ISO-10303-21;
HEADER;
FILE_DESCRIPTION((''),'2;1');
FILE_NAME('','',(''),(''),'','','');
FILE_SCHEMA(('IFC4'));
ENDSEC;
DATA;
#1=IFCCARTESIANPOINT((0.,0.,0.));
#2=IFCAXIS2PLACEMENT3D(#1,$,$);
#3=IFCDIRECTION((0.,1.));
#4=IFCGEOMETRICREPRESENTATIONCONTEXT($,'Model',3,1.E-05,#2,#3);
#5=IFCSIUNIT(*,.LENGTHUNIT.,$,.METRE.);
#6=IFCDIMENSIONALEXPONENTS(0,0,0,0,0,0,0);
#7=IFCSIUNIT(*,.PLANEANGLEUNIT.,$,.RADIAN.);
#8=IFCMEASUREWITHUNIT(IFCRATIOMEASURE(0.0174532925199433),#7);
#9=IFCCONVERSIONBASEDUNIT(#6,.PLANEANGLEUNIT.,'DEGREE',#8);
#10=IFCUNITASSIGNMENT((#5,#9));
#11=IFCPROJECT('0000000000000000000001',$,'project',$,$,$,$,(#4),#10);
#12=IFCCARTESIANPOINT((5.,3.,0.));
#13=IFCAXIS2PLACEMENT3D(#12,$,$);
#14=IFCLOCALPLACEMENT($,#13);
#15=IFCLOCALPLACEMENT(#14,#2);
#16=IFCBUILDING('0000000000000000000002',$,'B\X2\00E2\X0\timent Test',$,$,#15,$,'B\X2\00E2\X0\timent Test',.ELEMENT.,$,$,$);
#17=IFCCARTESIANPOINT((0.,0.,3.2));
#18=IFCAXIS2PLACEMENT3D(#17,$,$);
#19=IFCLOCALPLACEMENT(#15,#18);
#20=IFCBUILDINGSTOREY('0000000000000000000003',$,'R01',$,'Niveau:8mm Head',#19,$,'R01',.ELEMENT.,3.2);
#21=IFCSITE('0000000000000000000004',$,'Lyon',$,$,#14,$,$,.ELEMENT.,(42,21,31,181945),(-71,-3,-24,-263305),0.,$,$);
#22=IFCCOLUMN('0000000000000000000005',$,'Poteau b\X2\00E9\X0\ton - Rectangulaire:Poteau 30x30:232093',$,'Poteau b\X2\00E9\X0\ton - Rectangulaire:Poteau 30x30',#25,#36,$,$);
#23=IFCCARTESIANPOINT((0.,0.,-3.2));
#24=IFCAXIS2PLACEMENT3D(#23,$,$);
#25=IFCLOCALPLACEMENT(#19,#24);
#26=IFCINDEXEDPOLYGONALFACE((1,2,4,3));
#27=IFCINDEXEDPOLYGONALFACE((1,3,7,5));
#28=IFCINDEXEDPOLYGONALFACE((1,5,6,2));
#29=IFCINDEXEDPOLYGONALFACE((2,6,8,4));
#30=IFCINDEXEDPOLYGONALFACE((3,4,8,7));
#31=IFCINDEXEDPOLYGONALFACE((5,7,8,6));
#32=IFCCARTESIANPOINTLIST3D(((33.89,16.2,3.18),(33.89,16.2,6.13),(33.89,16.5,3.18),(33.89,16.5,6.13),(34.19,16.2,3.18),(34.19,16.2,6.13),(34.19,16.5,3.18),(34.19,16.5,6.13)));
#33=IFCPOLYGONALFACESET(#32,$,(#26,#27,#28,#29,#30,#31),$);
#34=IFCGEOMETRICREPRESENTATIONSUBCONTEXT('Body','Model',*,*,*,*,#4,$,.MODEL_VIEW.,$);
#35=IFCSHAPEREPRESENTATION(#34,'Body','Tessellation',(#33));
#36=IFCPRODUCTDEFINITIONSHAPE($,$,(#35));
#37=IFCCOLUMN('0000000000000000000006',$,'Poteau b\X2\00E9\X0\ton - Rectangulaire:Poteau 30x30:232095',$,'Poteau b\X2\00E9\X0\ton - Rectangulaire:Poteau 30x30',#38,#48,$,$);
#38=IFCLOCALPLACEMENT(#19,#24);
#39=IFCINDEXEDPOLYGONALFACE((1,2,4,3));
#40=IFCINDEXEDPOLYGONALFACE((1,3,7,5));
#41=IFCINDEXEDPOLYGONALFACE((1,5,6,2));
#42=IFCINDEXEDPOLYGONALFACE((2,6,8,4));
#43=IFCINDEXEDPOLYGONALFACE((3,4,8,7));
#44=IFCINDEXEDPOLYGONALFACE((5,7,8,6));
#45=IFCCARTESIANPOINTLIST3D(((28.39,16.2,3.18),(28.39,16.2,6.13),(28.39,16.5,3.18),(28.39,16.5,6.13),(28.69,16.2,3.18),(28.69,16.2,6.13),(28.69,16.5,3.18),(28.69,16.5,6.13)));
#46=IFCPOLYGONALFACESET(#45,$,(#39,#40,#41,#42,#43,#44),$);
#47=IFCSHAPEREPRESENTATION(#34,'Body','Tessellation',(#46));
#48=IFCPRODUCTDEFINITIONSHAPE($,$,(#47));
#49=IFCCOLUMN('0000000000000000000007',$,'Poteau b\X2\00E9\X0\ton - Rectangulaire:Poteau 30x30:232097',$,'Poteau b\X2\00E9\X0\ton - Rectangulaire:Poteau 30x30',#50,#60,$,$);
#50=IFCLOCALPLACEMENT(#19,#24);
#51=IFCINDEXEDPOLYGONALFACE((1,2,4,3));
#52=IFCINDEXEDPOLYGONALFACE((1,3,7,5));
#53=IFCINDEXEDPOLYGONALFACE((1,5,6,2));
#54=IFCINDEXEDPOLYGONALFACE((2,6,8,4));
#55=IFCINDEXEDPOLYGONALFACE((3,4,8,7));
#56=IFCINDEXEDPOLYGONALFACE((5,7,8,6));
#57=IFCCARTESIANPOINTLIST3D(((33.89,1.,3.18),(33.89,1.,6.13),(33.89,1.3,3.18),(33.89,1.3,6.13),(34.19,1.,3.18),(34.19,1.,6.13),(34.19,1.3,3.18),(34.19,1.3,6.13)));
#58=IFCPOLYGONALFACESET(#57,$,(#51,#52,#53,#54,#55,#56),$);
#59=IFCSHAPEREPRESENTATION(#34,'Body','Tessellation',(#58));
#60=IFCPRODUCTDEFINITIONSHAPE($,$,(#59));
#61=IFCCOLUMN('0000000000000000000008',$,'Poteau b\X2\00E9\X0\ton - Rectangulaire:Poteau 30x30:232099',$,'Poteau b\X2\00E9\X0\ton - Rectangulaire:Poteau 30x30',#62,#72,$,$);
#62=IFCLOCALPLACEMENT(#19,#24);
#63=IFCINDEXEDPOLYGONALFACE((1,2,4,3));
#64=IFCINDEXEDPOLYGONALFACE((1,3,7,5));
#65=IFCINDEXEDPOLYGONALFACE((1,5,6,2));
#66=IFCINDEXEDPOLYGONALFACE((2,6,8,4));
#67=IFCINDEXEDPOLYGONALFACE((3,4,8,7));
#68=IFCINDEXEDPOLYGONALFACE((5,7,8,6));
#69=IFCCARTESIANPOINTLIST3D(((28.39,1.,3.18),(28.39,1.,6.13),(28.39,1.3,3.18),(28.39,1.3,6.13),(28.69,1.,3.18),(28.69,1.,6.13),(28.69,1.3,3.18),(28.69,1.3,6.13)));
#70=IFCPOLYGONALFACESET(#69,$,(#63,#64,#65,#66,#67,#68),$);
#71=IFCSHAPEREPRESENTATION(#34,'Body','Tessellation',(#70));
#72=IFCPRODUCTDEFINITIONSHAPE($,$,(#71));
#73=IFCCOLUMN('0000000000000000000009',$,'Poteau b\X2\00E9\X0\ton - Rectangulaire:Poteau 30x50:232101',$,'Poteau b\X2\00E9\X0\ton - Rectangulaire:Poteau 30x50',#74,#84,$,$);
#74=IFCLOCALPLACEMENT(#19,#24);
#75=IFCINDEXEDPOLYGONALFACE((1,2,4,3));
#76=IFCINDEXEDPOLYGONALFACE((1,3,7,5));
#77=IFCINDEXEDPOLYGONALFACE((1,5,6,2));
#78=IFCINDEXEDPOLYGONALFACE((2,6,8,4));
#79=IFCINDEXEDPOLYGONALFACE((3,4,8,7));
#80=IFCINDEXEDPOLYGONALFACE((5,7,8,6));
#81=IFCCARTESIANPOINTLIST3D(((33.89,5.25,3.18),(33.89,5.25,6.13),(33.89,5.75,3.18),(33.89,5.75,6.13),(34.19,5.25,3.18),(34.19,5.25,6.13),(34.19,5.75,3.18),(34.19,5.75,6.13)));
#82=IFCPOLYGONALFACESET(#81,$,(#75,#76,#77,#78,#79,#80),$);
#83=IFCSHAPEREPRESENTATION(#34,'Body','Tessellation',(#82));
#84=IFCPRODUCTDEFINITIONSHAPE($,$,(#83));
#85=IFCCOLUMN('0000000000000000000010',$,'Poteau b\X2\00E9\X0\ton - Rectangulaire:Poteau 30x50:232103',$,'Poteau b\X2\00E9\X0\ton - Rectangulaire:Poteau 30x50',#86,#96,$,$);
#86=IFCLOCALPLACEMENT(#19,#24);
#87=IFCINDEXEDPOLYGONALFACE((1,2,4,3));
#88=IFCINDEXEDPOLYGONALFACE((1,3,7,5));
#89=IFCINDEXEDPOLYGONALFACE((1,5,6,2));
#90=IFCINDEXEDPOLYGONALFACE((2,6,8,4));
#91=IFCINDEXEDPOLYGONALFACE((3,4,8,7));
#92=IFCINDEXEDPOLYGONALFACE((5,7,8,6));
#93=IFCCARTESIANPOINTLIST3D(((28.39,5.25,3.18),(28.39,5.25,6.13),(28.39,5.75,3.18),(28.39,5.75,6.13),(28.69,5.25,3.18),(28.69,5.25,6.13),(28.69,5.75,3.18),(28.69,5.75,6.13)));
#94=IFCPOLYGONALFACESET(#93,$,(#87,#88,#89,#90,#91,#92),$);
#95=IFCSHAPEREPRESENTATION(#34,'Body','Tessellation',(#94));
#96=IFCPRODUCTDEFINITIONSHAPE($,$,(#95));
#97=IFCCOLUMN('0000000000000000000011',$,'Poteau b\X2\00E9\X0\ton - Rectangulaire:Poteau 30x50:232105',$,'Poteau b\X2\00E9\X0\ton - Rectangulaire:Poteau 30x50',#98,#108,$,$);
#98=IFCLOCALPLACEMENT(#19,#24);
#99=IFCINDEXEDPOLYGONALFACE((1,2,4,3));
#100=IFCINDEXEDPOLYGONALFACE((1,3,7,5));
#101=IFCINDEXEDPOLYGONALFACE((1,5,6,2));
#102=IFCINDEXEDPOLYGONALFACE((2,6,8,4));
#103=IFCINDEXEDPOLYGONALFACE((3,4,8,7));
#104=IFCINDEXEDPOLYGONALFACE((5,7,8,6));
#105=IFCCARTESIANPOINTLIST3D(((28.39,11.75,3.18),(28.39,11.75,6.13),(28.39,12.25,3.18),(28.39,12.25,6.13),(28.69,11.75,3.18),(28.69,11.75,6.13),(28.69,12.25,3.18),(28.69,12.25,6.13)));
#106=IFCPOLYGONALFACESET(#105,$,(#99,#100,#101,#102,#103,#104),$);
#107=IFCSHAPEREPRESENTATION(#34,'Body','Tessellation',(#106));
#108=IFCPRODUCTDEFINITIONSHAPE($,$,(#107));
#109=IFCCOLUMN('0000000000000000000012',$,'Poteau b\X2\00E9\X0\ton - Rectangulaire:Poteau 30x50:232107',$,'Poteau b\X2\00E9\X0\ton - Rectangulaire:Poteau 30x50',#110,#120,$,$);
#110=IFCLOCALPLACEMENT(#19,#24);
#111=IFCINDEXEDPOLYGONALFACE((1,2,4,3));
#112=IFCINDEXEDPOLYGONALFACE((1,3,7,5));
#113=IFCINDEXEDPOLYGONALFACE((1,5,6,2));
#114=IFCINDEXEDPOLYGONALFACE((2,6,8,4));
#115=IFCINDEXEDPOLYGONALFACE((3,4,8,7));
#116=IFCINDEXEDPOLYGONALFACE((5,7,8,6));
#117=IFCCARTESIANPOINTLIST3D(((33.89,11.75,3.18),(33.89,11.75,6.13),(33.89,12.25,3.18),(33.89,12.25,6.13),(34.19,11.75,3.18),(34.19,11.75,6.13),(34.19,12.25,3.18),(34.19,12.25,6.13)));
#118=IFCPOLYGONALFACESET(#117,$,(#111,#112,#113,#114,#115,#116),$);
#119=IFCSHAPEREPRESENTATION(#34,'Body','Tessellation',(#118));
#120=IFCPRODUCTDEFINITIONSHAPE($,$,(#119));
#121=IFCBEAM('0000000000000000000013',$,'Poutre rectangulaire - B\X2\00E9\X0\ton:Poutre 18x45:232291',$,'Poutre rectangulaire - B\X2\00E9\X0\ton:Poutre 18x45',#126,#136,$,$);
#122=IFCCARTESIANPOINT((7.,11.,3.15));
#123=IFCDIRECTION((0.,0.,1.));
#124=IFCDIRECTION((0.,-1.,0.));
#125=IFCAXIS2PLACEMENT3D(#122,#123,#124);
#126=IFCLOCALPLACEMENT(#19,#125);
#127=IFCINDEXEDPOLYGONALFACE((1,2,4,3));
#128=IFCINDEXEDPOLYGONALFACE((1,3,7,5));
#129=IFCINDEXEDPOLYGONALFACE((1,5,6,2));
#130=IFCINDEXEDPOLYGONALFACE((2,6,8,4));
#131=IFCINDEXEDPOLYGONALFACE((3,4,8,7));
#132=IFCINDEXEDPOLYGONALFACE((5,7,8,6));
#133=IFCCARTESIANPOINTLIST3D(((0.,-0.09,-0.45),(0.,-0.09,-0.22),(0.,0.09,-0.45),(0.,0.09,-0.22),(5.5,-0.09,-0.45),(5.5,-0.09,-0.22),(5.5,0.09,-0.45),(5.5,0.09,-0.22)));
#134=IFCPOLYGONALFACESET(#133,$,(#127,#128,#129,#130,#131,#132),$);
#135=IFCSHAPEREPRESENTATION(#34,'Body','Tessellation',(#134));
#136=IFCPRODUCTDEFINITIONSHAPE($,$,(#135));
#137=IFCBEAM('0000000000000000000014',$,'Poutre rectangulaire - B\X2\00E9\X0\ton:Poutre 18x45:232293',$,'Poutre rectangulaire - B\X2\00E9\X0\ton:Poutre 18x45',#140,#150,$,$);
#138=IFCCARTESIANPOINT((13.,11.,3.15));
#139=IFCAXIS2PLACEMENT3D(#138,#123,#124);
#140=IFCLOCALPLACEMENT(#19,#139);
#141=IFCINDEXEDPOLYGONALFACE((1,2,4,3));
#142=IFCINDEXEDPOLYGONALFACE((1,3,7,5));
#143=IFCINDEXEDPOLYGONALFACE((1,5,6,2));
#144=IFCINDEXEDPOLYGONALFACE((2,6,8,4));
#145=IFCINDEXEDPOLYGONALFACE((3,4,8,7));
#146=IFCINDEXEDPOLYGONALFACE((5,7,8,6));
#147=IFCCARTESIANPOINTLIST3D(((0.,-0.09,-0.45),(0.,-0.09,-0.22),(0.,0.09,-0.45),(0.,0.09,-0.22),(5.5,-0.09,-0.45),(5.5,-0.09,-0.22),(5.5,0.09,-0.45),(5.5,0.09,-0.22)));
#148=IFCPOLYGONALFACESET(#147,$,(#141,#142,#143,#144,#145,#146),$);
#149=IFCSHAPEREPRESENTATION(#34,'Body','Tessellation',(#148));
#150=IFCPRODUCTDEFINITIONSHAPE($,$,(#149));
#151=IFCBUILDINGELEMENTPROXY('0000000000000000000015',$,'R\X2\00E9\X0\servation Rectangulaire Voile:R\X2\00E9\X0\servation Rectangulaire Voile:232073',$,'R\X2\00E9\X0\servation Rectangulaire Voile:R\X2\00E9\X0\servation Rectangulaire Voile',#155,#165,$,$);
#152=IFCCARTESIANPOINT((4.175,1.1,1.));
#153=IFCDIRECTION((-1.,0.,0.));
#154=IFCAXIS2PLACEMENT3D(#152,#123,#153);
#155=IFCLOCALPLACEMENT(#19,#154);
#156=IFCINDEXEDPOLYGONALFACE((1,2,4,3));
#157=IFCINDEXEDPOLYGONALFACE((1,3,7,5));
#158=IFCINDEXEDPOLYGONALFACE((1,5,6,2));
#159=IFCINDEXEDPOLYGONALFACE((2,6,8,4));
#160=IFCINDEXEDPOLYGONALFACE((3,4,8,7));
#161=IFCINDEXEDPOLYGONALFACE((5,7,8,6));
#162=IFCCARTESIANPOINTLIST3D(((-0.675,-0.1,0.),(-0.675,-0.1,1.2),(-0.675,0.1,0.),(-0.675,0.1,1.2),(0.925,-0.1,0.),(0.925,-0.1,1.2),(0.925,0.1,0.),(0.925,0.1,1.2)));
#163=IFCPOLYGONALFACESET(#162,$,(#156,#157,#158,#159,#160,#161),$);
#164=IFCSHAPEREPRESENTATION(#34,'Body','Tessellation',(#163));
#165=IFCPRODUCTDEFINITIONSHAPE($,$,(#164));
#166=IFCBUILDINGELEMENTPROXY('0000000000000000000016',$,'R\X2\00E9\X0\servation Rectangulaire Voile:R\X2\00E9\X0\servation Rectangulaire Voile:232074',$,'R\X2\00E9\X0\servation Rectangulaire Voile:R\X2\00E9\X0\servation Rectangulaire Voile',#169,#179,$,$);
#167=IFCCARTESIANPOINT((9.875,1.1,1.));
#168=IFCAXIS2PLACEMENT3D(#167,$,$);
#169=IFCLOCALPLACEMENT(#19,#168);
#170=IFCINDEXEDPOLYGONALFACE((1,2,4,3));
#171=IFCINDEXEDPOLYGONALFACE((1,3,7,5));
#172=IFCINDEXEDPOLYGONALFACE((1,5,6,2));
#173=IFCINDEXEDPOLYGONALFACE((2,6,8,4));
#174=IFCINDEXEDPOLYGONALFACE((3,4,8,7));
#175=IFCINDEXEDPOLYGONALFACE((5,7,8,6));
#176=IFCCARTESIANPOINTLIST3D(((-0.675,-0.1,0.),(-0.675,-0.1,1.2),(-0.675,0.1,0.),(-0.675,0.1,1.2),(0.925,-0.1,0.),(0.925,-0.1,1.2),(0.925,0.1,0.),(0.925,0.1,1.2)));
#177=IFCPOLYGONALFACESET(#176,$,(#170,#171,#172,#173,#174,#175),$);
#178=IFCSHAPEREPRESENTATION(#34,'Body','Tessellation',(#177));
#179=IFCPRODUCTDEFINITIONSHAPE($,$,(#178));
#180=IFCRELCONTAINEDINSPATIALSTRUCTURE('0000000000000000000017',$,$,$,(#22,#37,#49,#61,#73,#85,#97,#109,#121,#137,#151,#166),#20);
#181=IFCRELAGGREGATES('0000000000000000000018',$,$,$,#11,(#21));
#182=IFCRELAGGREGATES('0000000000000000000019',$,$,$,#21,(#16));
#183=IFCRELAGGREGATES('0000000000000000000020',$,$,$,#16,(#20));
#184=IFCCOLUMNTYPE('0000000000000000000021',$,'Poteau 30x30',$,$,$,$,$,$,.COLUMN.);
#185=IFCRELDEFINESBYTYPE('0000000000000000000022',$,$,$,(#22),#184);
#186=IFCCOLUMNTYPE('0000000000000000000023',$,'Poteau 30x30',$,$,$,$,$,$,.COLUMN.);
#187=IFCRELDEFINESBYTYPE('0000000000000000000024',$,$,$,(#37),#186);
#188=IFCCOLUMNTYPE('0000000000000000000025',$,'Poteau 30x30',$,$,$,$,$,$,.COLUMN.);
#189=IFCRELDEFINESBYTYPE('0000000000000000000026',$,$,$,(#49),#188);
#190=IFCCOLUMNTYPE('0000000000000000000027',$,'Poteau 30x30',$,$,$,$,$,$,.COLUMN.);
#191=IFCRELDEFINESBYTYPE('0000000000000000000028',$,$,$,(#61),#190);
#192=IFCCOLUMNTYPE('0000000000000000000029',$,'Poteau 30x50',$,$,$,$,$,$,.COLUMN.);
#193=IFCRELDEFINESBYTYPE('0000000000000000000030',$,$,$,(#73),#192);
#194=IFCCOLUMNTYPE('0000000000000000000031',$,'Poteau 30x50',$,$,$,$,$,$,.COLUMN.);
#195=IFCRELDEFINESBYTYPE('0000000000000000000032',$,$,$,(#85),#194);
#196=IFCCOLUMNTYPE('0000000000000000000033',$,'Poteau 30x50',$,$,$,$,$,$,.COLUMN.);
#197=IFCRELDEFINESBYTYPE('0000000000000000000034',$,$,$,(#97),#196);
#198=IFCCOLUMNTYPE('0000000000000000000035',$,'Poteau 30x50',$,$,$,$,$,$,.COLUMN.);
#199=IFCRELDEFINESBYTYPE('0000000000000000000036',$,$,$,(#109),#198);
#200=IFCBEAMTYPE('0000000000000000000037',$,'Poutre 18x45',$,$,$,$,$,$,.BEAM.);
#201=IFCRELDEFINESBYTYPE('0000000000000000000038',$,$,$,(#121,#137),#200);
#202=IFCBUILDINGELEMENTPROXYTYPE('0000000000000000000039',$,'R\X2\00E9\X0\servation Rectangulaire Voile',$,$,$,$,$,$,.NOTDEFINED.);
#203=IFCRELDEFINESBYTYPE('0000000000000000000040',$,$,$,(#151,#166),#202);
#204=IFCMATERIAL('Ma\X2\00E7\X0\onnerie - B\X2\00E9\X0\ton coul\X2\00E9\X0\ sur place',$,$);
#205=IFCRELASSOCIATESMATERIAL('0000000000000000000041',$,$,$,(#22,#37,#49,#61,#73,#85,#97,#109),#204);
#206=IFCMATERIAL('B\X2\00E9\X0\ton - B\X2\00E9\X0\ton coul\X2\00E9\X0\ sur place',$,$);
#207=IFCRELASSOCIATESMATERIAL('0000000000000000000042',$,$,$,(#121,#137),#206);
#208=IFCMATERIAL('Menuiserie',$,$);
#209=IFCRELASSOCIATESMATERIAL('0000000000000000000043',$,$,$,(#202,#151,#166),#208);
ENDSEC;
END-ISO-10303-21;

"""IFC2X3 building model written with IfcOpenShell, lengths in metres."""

from ifc_helpers import new_model, entity, si_unit, converted_unit, direction, frame, frame_2d, origin, origin_2d_with_axis, place, context, subcontext, project, spatial, rectangle, extrude, source, transform, mapped, material, type_object, type_shapes, element, save


model = new_model("IFC2X3")

# Units and contexts
model_context = context("Model", 3, precision=1e-05, world=origin(), true_north=direction((0.0, 1.0)))
body_context = subcontext(model_context, "Body", "Model", "MODEL_VIEW")
ifc_project = project(units=[si_unit("LENGTHUNIT", "METRE"), converted_unit("PLANEANGLEUNIT", "DEGREE", entity("IfcRatioMeasure", 0.0174532925199433), si_unit("PLANEANGLEUNIT", "RADIAN"), dimensions=[0, 0, 0, 0, 0, 0, 0])], contexts=[model_context])

# Site, building, storey
site_placement = place(None, frame((5.0, 3.0, 0.0)))
site = spatial("IfcSite", under=ifc_project, at=site_placement, Name="Lyon", CompositionType="ELEMENT", RefLatitude=(42, 21, 31, 181945), RefLongitude=(-71, -3, -24, -263305), RefElevation=0.0)
building_placement = place(site_placement, origin())
building = spatial("IfcBuilding", under=site, at=building_placement, Name="Bâtiment Test", LongName="Bâtiment Test", CompositionType="ELEMENT")
storey_placement = place(building_placement, frame((0.0, 0.0, 3.2)))
storey = spatial("IfcBuildingStorey", under=building, at=storey_placement, Name="R01", ObjectType="Niveau:8mm Head", LongName="R01", CompositionType="ELEMENT", Elevation=3.2)

# Columns
ifc_material_1 = material(Name="Maçonnerie - Béton coulé sur place")
column_type_1 = type_object("IfcColumnType", Name="Poteau 30x30", PredefinedType="COLUMN")
shared_shape_1 = source(origin(), body_context, "Body", "SweptSolid", [
    extrude(rectangle(XDim=0.3, YDim=0.3, at=origin_2d_with_axis()), frame((34.04, 16.35, 3.18), z_axis=(0.0, 0.0, 1.0), x_axis=(0.0, -1.0, 0.0)), (0.0, 0.0, 1.0), 2.95),
])
type_shapes(column_type_1, [shared_shape_1])
column_1_placement = place(storey_placement, frame((0.0, 0.0, -3.2)))
element("IfcColumn", 1, at=column_1_placement, inside=storey, type_object=column_type_1, material=ifc_material_1, Name="Poteau béton - Rectangulaire:Poteau 30x30:232093", ObjectType="Poteau béton - Rectangulaire:Poteau 30x30", context=body_context, shape_type="MappedRepresentation", body=[
    mapped(shared_shape_1, transform((0.0, 0.0, 0.0), scale=1.0)),
])
column_type_2 = type_object("IfcColumnType", Name="Poteau 30x30", PredefinedType="COLUMN")
shared_shape_2 = source(origin(), body_context, "Body", "SweptSolid", [
    extrude(rectangle(XDim=0.3, YDim=0.3, at=origin_2d_with_axis()), frame((28.54, 16.35, 3.18), z_axis=(0.0, 0.0, 1.0), x_axis=(0.0, -1.0, 0.0)), (0.0, 0.0, 1.0), 2.95),
])
type_shapes(column_type_2, [shared_shape_2])
column_2_placement = place(storey_placement, frame((0.0, 0.0, -3.2)))
element("IfcColumn", 2, at=column_2_placement, inside=storey, type_object=column_type_2, material=ifc_material_1, Name="Poteau béton - Rectangulaire:Poteau 30x30:232095", ObjectType="Poteau béton - Rectangulaire:Poteau 30x30", context=body_context, shape_type="MappedRepresentation", body=[
    mapped(shared_shape_2, transform((0.0, 0.0, 0.0), scale=1.0)),
])
column_type_3 = type_object("IfcColumnType", Name="Poteau 30x30", PredefinedType="COLUMN")
shared_shape_3 = source(origin(), body_context, "Body", "SweptSolid", [
    extrude(rectangle(XDim=0.3, YDim=0.3, at=frame_2d((0.0, 0.0), x_axis=(1.0, 0.0))), frame((34.04, 1.15, 3.18), z_axis=(0.0, 0.0, 1.0), x_axis=(0.0, -1.0, 0.0)), (0.0, 0.0, 1.0), 2.95),
])
type_shapes(column_type_3, [shared_shape_3])
column_3_placement = place(storey_placement, frame((0.0, 0.0, -3.2)))
element("IfcColumn", 3, at=column_3_placement, inside=storey, type_object=column_type_3, material=ifc_material_1, Name="Poteau béton - Rectangulaire:Poteau 30x30:232097", ObjectType="Poteau béton - Rectangulaire:Poteau 30x30", context=body_context, shape_type="MappedRepresentation", body=[
    mapped(shared_shape_3, transform((0.0, 0.0, 0.0), scale=1.0)),
])
column_type_4 = type_object("IfcColumnType", Name="Poteau 30x30", PredefinedType="COLUMN")
shared_shape_4 = source(origin(), body_context, "Body", "SweptSolid", [
    extrude(rectangle(XDim=0.3, YDim=0.3, at=frame_2d((0.0, 0.0), x_axis=(1.0, 0.0))), frame((28.54, 1.15, 3.18), z_axis=(0.0, 0.0, 1.0), x_axis=(0.0, -1.0, 0.0)), (0.0, 0.0, 1.0), 2.95),
])
type_shapes(column_type_4, [shared_shape_4])
column_4_placement = place(storey_placement, frame((0.0, 0.0, -3.2)))
element("IfcColumn", 4, at=column_4_placement, inside=storey, type_object=column_type_4, material=ifc_material_1, Name="Poteau béton - Rectangulaire:Poteau 30x30:232099", ObjectType="Poteau béton - Rectangulaire:Poteau 30x30", context=body_context, shape_type="MappedRepresentation", body=[
    mapped(shared_shape_4, transform((0.0, 0.0, 0.0), scale=1.0)),
])
column_type_5 = type_object("IfcColumnType", Name="Poteau 30x50", PredefinedType="COLUMN")
shared_shape_5 = source(origin(), body_context, "Body", "SweptSolid", [
    extrude(rectangle(XDim=0.5, YDim=0.3, at=origin_2d_with_axis()), frame((34.04, 5.5, 3.18), z_axis=(0.0, 0.0, 1.0), x_axis=(0.0, -1.0, 0.0)), (0.0, 0.0, 1.0), 2.95),
])
type_shapes(column_type_5, [shared_shape_5])
column_5_placement = place(storey_placement, frame((0.0, 0.0, -3.2)))
element("IfcColumn", 5, at=column_5_placement, inside=storey, type_object=column_type_5, material=ifc_material_1, Name="Poteau béton - Rectangulaire:Poteau 30x50:232101", ObjectType="Poteau béton - Rectangulaire:Poteau 30x50", context=body_context, shape_type="MappedRepresentation", body=[
    mapped(shared_shape_5, transform((0.0, 0.0, 0.0), scale=1.0)),
])
column_type_6 = type_object("IfcColumnType", Name="Poteau 30x50", PredefinedType="COLUMN")
shared_shape_6 = source(origin(), body_context, "Body", "SweptSolid", [
    extrude(rectangle(XDim=0.5, YDim=0.3, at=origin_2d_with_axis()), frame((28.54, 5.5, 3.18), z_axis=(0.0, 0.0, 1.0), x_axis=(0.0, -1.0, 0.0)), (0.0, 0.0, 1.0), 2.95),
])
type_shapes(column_type_6, [shared_shape_6])
column_6_placement = place(storey_placement, frame((0.0, 0.0, -3.2)))
element("IfcColumn", 6, at=column_6_placement, inside=storey, type_object=column_type_6, material=ifc_material_1, Name="Poteau béton - Rectangulaire:Poteau 30x50:232103", ObjectType="Poteau béton - Rectangulaire:Poteau 30x50", context=body_context, shape_type="MappedRepresentation", body=[
    mapped(shared_shape_6, transform((0.0, 0.0, 0.0), scale=1.0)),
])
column_type_7 = type_object("IfcColumnType", Name="Poteau 30x50", PredefinedType="COLUMN")
shared_shape_7 = source(origin(), body_context, "Body", "SweptSolid", [
    extrude(rectangle(XDim=0.5, YDim=0.3, at=origin_2d_with_axis()), frame((28.54, 12.0, 3.18), z_axis=(0.0, 0.0, 1.0), x_axis=(0.0, -1.0, 0.0)), (0.0, 0.0, 1.0), 2.95),
])
type_shapes(column_type_7, [shared_shape_7])
column_7_placement = place(storey_placement, frame((0.0, 0.0, -3.2)))
element("IfcColumn", 7, at=column_7_placement, inside=storey, type_object=column_type_7, material=ifc_material_1, Name="Poteau béton - Rectangulaire:Poteau 30x50:232105", ObjectType="Poteau béton - Rectangulaire:Poteau 30x50", context=body_context, shape_type="MappedRepresentation", body=[
    mapped(shared_shape_7, transform((0.0, 0.0, 0.0), scale=1.0)),
])
column_type_8 = type_object("IfcColumnType", Name="Poteau 30x50", PredefinedType="COLUMN")
shared_shape_8 = source(origin(), body_context, "Body", "SweptSolid", [
    extrude(rectangle(XDim=0.5, YDim=0.3, at=origin_2d_with_axis()), frame((34.04, 12.0, 3.18), z_axis=(0.0, 0.0, 1.0), x_axis=(0.0, -1.0, 0.0)), (0.0, 0.0, 1.0), 2.95),
])
type_shapes(column_type_8, [shared_shape_8])
column_8_placement = place(storey_placement, frame((0.0, 0.0, -3.2)))
element("IfcColumn", 8, at=column_8_placement, inside=storey, type_object=column_type_8, material=ifc_material_1, Name="Poteau béton - Rectangulaire:Poteau 30x50:232107", ObjectType="Poteau béton - Rectangulaire:Poteau 30x50", context=body_context, shape_type="MappedRepresentation", body=[
    mapped(shared_shape_8, transform((0.0, 0.0, 0.0), scale=1.0)),
])

# Beams
ifc_material_2 = material(Name="Béton - Béton coulé sur place")
beam_type = type_object("IfcBeamType", Name="Poutre 18x45", PredefinedType="BEAM")
beam_1_placement = place(storey_placement, frame((7.0, 11.0, 3.15), z_axis=(0.0, 0.0, 1.0), x_axis=(0.0, -1.0, 0.0)))
element("IfcBeam", 9, at=beam_1_placement, inside=storey, type_object=beam_type, material=ifc_material_2, Name="Poutre rectangulaire - Béton:Poutre 18x45:232291", ObjectType="Poutre rectangulaire - Béton:Poutre 18x45", context=body_context, shape_type="SweptSolid", body=[
    extrude(rectangle(XDim=0.23, YDim=0.18, at=origin_2d_with_axis()), frame((0.0, 0.0, -0.335), z_axis=(1.0, 0.0, 0.0), x_axis=(0.0, 0.0, -1.0)), (0.0, 0.0, 1.0), 5.5),
])
beam_2_placement = place(storey_placement, frame((13.0, 11.0, 3.15), z_axis=(0.0, 0.0, 1.0), x_axis=(0.0, -1.0, 0.0)))
element("IfcBeam", 10, at=beam_2_placement, inside=storey, type_object=beam_type, material=ifc_material_2, Name="Poutre rectangulaire - Béton:Poutre 18x45:232293", ObjectType="Poutre rectangulaire - Béton:Poutre 18x45", context=body_context, shape_type="SweptSolid", body=[
    extrude(rectangle(XDim=0.23, YDim=0.18, at=frame_2d((0.0, 0.0), x_axis=(1.0, 0.0))), frame((0.0, 0.0, -0.335), z_axis=(1.0, 0.0, 0.0), x_axis=(0.0, 0.0, -1.0)), (0.0, 0.0, 1.0), 5.5),
])

# Building element proxies
ifc_material_3 = material(Name="Menuiserie")
building_element_proxy_type_1 = type_object("IfcBuildingElementProxyType", Name="Réservation Rectangulaire Voile", PredefinedType="NOTDEFINED", material=ifc_material_3)
shared_shape_9 = source(origin(), body_context, "Body", "SweptSolid", [
    extrude(rectangle(XDim=0.2, YDim=1.6, at=origin_2d_with_axis()), frame((0.125, 0.0, 0.0), z_axis=(0.0, 0.0, 1.0), x_axis=(0.0, 1.0, 0.0)), (0.0, 0.0, 1.0), 1.2),
])
type_shapes(building_element_proxy_type_1, [shared_shape_9])
proxy_1_placement = place(storey_placement, frame((4.175, 1.1, 1.0), z_axis=(0.0, 0.0, 1.0), x_axis=(-1.0, 0.0, 0.0)))
element("IfcBuildingElementProxy", 11, at=proxy_1_placement, inside=storey, type_object=building_element_proxy_type_1, material=ifc_material_3, Name="Réservation Rectangulaire Voile:Réservation Rectangulaire Voile:232073", ObjectType="Réservation Rectangulaire Voile:Réservation Rectangulaire Voile", context=body_context, shape_type="MappedRepresentation", body=[
    mapped(shared_shape_9, transform((0.0, 0.0, 0.0), scale=1.0)),
])
proxy_2_placement = place(storey_placement, frame((9.875, 1.1, 1.0)))
element("IfcBuildingElementProxy", 12, at=proxy_2_placement, inside=storey, type_object=building_element_proxy_type_1, material=ifc_material_3, Name="Réservation Rectangulaire Voile:Réservation Rectangulaire Voile:232074", ObjectType="Réservation Rectangulaire Voile:Réservation Rectangulaire Voile", context=body_context, shape_type="MappedRepresentation", body=[
    mapped(shared_shape_9, transform((0.0, 0.0, 0.0), scale=1.0)),
])

save(model, "model.ifc")
